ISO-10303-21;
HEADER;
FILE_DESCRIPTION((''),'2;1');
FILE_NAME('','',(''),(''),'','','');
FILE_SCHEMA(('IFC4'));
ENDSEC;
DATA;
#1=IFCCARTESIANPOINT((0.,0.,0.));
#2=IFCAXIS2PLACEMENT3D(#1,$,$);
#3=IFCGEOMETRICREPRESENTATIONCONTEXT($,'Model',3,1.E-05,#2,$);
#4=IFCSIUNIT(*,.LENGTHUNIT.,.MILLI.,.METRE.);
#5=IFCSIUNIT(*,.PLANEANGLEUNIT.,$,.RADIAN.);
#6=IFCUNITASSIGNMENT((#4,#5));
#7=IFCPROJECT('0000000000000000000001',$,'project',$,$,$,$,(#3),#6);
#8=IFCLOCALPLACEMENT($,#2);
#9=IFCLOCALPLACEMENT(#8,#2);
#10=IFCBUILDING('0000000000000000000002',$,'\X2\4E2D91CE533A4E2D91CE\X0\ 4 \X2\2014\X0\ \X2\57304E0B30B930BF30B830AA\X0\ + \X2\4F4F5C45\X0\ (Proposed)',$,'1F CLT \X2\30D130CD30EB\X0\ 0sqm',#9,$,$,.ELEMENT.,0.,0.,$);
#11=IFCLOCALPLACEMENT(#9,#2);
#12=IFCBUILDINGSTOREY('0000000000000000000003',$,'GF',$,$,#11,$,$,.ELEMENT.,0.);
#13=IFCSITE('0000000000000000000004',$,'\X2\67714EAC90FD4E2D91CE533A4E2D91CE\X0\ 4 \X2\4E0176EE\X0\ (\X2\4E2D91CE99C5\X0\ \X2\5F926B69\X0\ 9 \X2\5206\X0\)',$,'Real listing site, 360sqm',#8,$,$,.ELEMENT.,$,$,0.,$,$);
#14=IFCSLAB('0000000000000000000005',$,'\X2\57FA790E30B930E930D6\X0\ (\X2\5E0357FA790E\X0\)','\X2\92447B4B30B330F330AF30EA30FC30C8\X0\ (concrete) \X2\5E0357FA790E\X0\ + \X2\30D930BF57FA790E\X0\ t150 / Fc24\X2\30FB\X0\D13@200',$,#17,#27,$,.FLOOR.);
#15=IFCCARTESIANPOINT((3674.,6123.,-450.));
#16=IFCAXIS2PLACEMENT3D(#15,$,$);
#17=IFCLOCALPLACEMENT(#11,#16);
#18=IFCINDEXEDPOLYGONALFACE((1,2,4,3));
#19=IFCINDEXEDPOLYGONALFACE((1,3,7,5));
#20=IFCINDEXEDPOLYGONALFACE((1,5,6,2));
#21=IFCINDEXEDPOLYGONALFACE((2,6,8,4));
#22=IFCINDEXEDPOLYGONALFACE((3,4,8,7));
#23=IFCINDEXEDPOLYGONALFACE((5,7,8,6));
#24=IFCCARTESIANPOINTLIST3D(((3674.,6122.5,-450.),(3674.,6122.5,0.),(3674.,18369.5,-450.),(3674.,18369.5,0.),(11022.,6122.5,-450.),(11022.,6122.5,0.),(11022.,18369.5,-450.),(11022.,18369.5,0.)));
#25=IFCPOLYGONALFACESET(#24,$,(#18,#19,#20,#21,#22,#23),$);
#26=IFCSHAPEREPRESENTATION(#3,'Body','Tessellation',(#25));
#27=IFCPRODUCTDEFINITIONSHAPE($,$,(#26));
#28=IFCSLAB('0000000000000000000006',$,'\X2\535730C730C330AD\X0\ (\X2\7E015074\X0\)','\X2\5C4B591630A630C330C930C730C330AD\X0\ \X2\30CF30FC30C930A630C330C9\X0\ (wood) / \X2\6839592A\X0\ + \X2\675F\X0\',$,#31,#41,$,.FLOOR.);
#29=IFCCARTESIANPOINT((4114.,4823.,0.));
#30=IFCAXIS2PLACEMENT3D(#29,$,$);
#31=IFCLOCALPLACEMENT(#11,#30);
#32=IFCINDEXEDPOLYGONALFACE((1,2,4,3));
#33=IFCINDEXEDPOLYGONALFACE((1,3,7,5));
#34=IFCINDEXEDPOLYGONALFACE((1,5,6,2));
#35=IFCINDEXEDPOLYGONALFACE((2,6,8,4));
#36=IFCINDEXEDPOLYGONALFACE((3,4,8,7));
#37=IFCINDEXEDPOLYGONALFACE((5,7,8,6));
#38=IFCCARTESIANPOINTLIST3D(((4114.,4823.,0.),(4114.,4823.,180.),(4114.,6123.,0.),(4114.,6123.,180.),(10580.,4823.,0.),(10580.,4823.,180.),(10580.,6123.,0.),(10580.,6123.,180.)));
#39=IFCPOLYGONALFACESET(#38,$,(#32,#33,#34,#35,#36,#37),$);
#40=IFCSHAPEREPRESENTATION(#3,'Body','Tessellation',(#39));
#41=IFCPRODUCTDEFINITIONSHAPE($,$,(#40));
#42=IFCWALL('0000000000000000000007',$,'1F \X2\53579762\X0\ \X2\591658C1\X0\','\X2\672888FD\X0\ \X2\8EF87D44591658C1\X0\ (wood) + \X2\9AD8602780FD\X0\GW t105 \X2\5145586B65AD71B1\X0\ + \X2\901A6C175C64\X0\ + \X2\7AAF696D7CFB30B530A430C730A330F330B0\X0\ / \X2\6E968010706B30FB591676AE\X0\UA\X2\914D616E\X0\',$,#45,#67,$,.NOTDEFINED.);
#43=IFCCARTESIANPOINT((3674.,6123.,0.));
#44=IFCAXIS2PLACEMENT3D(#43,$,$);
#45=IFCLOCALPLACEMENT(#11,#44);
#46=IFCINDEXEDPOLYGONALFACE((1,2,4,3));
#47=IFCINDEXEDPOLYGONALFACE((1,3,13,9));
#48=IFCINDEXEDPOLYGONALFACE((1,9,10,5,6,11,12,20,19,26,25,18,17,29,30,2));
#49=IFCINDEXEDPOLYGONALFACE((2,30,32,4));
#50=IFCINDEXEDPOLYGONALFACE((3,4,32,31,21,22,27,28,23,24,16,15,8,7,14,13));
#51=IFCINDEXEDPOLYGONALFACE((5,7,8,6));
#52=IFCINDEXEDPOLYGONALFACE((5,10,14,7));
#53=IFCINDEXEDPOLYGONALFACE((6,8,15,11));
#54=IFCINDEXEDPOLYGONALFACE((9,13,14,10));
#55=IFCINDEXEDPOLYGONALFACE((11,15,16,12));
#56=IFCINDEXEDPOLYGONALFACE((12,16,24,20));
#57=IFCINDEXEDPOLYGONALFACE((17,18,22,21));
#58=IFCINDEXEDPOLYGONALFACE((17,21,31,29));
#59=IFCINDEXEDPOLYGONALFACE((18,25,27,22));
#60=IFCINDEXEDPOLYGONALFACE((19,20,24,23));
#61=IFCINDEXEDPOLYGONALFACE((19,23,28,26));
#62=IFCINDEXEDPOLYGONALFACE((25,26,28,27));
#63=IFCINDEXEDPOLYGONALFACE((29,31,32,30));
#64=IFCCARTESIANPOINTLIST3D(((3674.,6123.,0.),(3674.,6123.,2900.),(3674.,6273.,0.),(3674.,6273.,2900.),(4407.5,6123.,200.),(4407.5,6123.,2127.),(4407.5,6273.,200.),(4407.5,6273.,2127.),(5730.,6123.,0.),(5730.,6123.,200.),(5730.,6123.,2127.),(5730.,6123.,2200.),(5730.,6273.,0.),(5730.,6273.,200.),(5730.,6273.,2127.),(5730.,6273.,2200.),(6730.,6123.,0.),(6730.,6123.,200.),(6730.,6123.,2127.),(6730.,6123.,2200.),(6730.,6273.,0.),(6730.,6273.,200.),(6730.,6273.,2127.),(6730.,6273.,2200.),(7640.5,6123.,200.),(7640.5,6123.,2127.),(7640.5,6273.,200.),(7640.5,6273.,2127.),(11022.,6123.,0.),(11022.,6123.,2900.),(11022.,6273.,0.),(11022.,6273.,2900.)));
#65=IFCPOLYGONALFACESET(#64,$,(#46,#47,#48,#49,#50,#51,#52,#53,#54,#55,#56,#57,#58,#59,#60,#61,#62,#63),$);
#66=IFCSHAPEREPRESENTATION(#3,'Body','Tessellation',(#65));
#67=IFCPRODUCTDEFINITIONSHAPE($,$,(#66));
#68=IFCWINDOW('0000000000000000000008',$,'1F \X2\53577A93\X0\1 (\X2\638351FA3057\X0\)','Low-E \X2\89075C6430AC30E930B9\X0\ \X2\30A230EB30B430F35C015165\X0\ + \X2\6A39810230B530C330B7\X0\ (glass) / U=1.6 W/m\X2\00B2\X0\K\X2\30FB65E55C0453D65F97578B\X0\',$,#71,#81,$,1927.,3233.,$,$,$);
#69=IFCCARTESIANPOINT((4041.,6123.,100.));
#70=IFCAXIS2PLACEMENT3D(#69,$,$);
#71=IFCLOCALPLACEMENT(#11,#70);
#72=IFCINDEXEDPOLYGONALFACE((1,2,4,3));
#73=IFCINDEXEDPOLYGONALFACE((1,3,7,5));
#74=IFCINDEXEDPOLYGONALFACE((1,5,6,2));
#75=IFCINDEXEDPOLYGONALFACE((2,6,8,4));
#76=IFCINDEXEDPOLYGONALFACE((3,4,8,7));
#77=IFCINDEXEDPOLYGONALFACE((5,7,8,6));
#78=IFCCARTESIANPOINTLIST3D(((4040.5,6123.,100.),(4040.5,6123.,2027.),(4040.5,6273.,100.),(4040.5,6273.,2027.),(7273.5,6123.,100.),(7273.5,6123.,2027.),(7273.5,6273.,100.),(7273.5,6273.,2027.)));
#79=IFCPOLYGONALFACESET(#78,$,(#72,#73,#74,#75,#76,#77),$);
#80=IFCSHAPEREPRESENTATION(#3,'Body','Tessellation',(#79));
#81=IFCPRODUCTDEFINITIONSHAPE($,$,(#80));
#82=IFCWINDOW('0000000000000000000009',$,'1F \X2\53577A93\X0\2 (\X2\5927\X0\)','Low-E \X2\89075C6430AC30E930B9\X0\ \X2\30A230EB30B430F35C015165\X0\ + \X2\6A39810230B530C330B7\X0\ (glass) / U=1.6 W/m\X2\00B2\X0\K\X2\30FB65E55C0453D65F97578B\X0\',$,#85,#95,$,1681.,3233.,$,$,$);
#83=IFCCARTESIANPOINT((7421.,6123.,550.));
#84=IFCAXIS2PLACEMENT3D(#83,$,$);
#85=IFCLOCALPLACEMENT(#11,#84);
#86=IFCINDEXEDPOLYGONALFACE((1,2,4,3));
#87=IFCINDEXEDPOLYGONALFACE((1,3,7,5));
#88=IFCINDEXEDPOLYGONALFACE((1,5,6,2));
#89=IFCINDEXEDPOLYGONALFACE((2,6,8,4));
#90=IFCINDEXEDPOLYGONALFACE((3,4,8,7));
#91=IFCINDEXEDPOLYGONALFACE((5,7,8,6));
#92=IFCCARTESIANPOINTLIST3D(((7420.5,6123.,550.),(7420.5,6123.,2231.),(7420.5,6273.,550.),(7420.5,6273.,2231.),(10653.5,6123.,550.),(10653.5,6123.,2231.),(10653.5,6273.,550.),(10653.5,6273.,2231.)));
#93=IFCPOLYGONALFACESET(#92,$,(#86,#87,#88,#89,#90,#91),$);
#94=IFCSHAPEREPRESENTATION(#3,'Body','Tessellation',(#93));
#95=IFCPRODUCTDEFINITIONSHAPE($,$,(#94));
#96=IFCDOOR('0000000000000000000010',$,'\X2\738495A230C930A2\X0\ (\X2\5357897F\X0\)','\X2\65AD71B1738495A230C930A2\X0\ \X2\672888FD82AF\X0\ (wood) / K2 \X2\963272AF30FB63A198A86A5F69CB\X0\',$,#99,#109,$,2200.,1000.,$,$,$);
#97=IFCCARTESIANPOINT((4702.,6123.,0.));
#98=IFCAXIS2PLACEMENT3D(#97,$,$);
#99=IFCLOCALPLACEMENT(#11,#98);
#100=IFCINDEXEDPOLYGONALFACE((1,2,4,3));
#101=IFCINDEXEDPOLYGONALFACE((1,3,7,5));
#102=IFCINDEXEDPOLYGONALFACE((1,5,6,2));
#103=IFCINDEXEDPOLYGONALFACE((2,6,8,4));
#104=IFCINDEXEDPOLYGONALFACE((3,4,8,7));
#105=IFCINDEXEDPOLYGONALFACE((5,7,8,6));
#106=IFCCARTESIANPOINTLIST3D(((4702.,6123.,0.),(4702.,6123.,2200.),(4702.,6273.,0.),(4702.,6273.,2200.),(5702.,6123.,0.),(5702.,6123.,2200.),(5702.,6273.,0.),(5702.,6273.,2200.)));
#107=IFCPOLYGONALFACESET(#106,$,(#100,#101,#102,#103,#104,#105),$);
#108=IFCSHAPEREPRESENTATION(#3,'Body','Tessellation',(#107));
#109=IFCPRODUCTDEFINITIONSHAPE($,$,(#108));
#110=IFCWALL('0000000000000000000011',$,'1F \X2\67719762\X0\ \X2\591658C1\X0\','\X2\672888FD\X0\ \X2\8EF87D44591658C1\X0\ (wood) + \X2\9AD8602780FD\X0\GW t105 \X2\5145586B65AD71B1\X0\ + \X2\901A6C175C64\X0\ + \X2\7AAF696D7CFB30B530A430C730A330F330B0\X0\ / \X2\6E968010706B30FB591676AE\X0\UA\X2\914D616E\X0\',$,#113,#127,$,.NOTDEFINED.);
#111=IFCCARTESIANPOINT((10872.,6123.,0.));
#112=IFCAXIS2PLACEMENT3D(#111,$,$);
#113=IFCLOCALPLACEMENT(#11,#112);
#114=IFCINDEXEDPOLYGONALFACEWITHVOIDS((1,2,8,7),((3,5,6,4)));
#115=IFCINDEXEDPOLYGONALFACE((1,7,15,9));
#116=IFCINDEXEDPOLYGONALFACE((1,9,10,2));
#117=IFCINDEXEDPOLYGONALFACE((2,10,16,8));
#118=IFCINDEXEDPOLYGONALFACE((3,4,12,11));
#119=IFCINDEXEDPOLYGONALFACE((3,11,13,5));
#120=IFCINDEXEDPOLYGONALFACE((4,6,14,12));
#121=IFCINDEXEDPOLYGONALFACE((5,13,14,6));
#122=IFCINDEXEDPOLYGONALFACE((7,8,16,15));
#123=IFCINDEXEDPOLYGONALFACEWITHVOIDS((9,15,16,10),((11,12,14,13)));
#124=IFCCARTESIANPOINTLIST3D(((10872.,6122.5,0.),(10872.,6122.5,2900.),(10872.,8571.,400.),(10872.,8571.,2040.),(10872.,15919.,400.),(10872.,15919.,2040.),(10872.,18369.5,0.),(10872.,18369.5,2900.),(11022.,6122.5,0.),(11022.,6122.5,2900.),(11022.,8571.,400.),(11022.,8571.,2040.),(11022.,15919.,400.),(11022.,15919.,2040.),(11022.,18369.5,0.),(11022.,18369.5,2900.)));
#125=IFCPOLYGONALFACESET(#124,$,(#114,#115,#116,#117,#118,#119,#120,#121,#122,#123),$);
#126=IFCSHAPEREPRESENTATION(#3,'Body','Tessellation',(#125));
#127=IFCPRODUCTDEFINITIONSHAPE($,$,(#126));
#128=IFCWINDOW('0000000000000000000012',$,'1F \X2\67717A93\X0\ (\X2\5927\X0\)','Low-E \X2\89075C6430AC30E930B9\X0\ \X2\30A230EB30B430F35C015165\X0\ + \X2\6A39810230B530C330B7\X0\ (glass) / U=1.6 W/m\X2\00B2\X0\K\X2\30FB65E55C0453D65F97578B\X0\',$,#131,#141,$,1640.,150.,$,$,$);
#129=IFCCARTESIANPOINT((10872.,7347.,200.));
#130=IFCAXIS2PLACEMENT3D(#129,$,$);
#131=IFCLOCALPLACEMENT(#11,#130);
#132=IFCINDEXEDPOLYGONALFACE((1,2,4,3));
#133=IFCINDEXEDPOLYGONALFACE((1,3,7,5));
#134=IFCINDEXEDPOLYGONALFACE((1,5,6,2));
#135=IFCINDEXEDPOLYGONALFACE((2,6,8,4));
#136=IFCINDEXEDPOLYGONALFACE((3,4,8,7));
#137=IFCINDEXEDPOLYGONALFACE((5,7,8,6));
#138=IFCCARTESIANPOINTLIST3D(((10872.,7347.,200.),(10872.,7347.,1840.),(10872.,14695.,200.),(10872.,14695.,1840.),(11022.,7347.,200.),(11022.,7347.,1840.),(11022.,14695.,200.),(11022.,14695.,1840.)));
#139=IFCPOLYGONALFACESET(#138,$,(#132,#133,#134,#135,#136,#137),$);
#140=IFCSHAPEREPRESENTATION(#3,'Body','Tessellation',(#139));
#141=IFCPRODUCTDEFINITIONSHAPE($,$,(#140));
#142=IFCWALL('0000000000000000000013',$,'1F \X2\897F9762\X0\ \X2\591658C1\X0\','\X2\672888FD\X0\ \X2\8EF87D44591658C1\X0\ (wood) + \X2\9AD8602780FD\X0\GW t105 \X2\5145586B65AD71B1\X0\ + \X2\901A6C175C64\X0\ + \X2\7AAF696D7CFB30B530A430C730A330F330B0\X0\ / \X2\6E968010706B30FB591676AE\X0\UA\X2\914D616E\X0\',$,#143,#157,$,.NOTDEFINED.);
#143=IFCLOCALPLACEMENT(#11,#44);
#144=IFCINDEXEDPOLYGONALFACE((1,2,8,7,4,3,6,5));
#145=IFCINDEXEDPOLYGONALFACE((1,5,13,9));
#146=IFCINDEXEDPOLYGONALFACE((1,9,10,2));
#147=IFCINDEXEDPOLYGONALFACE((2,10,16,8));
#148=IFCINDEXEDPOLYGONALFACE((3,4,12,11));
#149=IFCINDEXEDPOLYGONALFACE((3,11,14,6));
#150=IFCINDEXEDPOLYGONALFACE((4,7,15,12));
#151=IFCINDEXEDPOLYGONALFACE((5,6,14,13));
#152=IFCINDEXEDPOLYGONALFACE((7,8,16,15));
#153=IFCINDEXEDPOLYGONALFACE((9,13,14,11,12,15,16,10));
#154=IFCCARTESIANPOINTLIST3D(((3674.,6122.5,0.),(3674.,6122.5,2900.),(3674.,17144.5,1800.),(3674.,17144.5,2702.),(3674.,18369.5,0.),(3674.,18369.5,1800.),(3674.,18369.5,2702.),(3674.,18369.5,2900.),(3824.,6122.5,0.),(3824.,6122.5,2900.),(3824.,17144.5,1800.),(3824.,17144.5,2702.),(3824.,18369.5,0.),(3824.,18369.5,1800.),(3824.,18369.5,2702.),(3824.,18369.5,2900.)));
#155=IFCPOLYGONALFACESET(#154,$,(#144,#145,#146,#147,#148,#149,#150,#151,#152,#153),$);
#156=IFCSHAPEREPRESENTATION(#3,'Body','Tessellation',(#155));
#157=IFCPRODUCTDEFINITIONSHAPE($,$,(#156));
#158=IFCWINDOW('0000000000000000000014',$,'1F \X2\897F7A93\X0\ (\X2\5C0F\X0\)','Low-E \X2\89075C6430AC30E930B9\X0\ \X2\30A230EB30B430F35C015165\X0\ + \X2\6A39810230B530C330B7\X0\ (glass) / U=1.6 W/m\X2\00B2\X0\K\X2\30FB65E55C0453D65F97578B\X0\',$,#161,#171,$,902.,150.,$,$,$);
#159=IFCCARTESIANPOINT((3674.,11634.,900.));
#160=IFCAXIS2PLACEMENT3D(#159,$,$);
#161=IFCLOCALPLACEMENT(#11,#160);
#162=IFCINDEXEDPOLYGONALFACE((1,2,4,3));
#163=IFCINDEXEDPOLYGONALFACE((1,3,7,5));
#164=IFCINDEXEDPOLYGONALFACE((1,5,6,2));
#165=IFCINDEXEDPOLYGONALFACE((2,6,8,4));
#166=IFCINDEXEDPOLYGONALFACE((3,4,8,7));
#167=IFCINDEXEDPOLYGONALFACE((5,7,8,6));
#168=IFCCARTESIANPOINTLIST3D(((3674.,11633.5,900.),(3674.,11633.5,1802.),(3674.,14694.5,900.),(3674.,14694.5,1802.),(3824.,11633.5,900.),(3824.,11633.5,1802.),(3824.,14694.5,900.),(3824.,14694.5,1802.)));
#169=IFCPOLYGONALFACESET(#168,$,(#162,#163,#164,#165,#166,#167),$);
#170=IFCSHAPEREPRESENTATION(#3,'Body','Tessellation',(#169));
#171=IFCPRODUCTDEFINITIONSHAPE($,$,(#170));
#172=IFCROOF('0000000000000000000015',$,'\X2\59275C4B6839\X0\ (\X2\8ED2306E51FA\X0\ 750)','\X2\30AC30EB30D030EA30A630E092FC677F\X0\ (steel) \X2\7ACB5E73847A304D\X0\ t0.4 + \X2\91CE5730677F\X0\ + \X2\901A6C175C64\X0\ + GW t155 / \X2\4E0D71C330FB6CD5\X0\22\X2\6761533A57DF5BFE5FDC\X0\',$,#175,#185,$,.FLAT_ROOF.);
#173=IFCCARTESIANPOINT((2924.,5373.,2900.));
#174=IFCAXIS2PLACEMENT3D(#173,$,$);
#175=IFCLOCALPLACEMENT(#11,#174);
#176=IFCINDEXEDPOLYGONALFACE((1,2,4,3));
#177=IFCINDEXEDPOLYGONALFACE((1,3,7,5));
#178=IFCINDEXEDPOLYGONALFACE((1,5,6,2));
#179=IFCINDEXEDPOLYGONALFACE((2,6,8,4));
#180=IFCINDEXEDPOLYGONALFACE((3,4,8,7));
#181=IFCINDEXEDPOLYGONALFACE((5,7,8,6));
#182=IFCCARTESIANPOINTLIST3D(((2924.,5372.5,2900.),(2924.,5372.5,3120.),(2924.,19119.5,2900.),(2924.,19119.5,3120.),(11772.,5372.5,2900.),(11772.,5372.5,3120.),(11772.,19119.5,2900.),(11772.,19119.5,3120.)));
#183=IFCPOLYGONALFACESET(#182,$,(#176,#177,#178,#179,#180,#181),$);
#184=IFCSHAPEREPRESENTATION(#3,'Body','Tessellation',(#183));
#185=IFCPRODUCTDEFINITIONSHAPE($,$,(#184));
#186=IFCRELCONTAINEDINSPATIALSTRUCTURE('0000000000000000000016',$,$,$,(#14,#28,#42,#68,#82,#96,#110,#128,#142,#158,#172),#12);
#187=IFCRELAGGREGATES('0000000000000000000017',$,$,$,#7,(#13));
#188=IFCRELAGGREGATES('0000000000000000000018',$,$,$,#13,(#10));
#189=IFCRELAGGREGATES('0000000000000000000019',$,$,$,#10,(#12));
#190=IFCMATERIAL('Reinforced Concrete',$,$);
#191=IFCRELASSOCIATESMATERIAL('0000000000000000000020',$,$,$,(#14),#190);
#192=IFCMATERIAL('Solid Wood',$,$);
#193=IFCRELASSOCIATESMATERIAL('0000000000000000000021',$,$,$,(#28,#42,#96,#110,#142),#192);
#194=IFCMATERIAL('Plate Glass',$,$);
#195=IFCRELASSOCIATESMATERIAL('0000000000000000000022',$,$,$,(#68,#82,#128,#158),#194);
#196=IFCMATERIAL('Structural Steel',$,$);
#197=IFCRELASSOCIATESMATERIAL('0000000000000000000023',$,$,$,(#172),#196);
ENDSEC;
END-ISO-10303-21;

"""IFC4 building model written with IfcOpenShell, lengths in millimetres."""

from ifc_helpers import new_model, si_unit, frame, frame_2d, origin, place, context, project, spatial, rectangle, extrude, material, element, fill, save


model = new_model("IFC4")

# Units and contexts
model_context = context("Model", 3, precision=1e-05, world=origin())
ifc_project = project(units=[si_unit("LENGTHUNIT", "METRE", prefix="MILLI"), si_unit("PLANEANGLEUNIT", "RADIAN")], contexts=[model_context])

# Site, building, storey
site_placement = place(None, origin())
site = spatial("IfcSite", under=ifc_project, at=site_placement, Name="東京都中野区中野 4 丁目 (中野駅 徒歩 9 分)", ObjectType="Real listing site, 360sqm", CompositionType="ELEMENT", RefElevation=0.0)
building_placement = place(site_placement, origin())
building = spatial("IfcBuilding", under=site, at=building_placement, Name="中野区中野 4 — 地下スタジオ + 住居 (Proposed)", ObjectType="1F CLT パネル 0sqm", CompositionType="ELEMENT", ElevationOfRefHeight=0.0, ElevationOfTerrain=0.0)
storey_placement = place(building_placement, origin())
storey = spatial("IfcBuildingStorey", under=building, at=storey_placement, Name="GF", CompositionType="ELEMENT", Elevation=0.0)

# Slabs
ifc_material_1 = material(Name="Reinforced Concrete")
slab_1_placement = place(storey_placement, frame((3674.0, 6123.0, -450.0)))
element("IfcSlab", 1, at=slab_1_placement, inside=storey, material=ifc_material_1, Name="基礎スラブ (布基礎)", Description="鉄筋コンクリート (concrete) 布基礎 + ベタ基礎 t150 / Fc24・D13@200", PredefinedType="FLOOR", context=model_context, shape_type="SweptSolid", body=[
    extrude(rectangle(XDim=7348.0, YDim=12247.0, at=frame_2d((3674.0, 6123.0))), frame((3674.0, 6123.0, -450.0)), (0.0, 0.0, 1.0), 450.0),
])
ifc_material_2 = material(Name="Solid Wood")
slab_2_placement = place(storey_placement, frame((4114.0, 4823.0, 0.0)))
element("IfcSlab", 2, at=slab_2_placement, inside=storey, material=ifc_material_2, Name="南デッキ (縁側)", Description="屋外ウッドデッキ ハードウッド (wood) / 根太 + 束", PredefinedType="FLOOR", context=model_context, shape_type="SweptSolid", body=[
    extrude(rectangle(XDim=6466.0, YDim=1300.0, at=frame_2d((3233.0, 650.0))), frame((4114.0, 4823.0, 0.0)), (0.0, 0.0, 1.0), 180.0),
])

# Wall, openings, windows, door
wall_1_placement = place(storey_placement, frame((3674.0, 6123.0, 0.0)))
wall_1 = element("IfcWall", 3, at=wall_1_placement, inside=storey, material=ifc_material_2, Name="1F 南面 外壁", Description="木製 軸組外壁 (wood) + 高性能GW t105 充填断熱 + 通気層 + 窯業系サイディング / 準耐火・外皮UA配慮", PredefinedType="NOTDEFINED", context=model_context, shape_type="SweptSolid", body=[
    extrude(rectangle(XDim=7348.0, YDim=150.0, at=frame_2d((3674.0, 75.0))), frame((3674.0, 6123.0, 0.0)), (0.0, 0.0, 1.0), 2900.0),
])
opening_1_placement = place(storey_placement, frame((4041.0, 6123.0, 100.0)))
opening_1 = element("IfcOpeningElement", 4, at=opening_1_placement, cuts=wall_1, PredefinedType="NOTDEFINED", context=model_context, shape_type="SweptSolid", body=[
    extrude(rectangle(XDim=3233.0, YDim=150.0, at=frame_2d((1616.0, 75.0))), frame((4041.0, 6123.0, 100.0)), (0.0, 0.0, 1.0), 1927.0),
])
opening_2_placement = place(storey_placement, frame((7421.0, 6123.0, 550.0)))
opening_2 = element("IfcOpeningElement", 5, at=opening_2_placement, cuts=wall_1, PredefinedType="NOTDEFINED", context=model_context, shape_type="SweptSolid", body=[
    extrude(rectangle(XDim=3233.0, YDim=150.0, at=frame_2d((1616.0, 75.0))), frame((7421.0, 6123.0, 550.0)), (0.0, 0.0, 1.0), 1681.0),
])
opening_3_placement = place(storey_placement, frame((4702.0, 6123.0, 0.0)))
opening_3 = element("IfcOpeningElement", 6, at=opening_3_placement, cuts=wall_1, PredefinedType="NOTDEFINED", context=model_context, shape_type="SweptSolid", body=[
    extrude(rectangle(XDim=1000.0, YDim=150.0, at=frame_2d((500.0, 75.0))), frame((4702.0, 6123.0, 0.0)), (0.0, 0.0, 1.0), 2200.0),
])
ifc_material_3 = material(Name="Plate Glass")
window_1_placement = place(storey_placement, frame((4041.0, 6123.0, 100.0)))
window_1 = element("IfcWindow", 7, at=window_1_placement, inside=storey, material=ifc_material_3, Name="1F 南窓1 (掃出し)", Description="Low-E 複層ガラス アルゴン封入 + 樹脂サッシ (glass) / U=1.6 W/m²K・日射取得型", OverallHeight=1927.0, OverallWidth=3233.0, context=model_context, shape_type="SweptSolid", body=[
    extrude(rectangle(XDim=3233.0, YDim=150.0, at=frame_2d((1616.0, 75.0))), frame((4041.0, 6123.0, 100.0)), (0.0, 0.0, 1.0), 1927.0),
])
fill(opening_1, window_1)
window_2_placement = place(storey_placement, frame((7421.0, 6123.0, 550.0)))
window_2 = element("IfcWindow", 8, at=window_2_placement, inside=storey, material=ifc_material_3, Name="1F 南窓2 (大)", Description="Low-E 複層ガラス アルゴン封入 + 樹脂サッシ (glass) / U=1.6 W/m²K・日射取得型", OverallHeight=1681.0, OverallWidth=3233.0, context=model_context, shape_type="SweptSolid", body=[
    extrude(rectangle(XDim=3233.0, YDim=150.0, at=frame_2d((1616.0, 75.0))), frame((7421.0, 6123.0, 550.0)), (0.0, 0.0, 1.0), 1681.0),
])
fill(opening_2, window_2)
door_placement = place(storey_placement, frame((4702.0, 6123.0, 0.0)))
door = element("IfcDoor", 9, at=door_placement, inside=storey, material=ifc_material_2, Name="玄関ドア (南西)", Description="断熱玄関ドア 木製芯 (wood) / K2 防犯・採風機構", OverallHeight=2200.0, OverallWidth=1000.0, context=model_context, shape_type="SweptSolid", body=[
    extrude(rectangle(XDim=1000.0, YDim=150.0, at=frame_2d((500.0, 75.0))), frame((4702.0, 6123.0, 0.0)), (0.0, 0.0, 1.0), 2200.0),
])
fill(opening_3, door)

# Walls, openings, windows
wall_2_placement = place(storey_placement, frame((10872.0, 6123.0, 0.0)))
wall_2 = element("IfcWall", 10, at=wall_2_placement, inside=storey, material=ifc_material_2, Name="1F 東面 外壁", Description="木製 軸組外壁 (wood) + 高性能GW t105 充填断熱 + 通気層 + 窯業系サイディング / 準耐火・外皮UA配慮", PredefinedType="NOTDEFINED", context=model_context, shape_type="SweptSolid", body=[
    extrude(rectangle(XDim=150.0, YDim=12247.0, at=frame_2d((75.0, 6123.0))), frame((10872.0, 6123.0, 0.0)), (0.0, 0.0, 1.0), 2900.0),
])
opening_4_placement = place(storey_placement, frame((10872.0, 7347.0, 200.0)))
opening_4 = element("IfcOpeningElement", 11, at=opening_4_placement, cuts=wall_2, PredefinedType="NOTDEFINED", context=model_context, shape_type="SweptSolid", body=[
    extrude(rectangle(XDim=150.0, YDim=7348.0, at=frame_2d((75.0, 3674.0))), frame((10872.0, 7347.0, 200.0)), (0.0, 0.0, 1.0), 1640.0),
])
window_3_placement = place(storey_placement, frame((10872.0, 7347.0, 200.0)))
window_3 = element("IfcWindow", 12, at=window_3_placement, inside=storey, material=ifc_material_3, Name="1F 東窓 (大)", Description="Low-E 複層ガラス アルゴン封入 + 樹脂サッシ (glass) / U=1.6 W/m²K・日射取得型", OverallHeight=1640.0, OverallWidth=150.0, context=model_context, shape_type="SweptSolid", body=[
    extrude(rectangle(XDim=150.0, YDim=7348.0, at=frame_2d((75.0, 3674.0))), frame((10872.0, 7347.0, 200.0)), (0.0, 0.0, 1.0), 1640.0),
])
fill(opening_4, window_3)
wall_3_placement = place(storey_placement, frame((3674.0, 6123.0, 0.0)))
wall_3 = element("IfcWall", 13, at=wall_3_placement, inside=storey, material=ifc_material_2, Name="1F 西面 外壁", Description="木製 軸組外壁 (wood) + 高性能GW t105 充填断熱 + 通気層 + 窯業系サイディング / 準耐火・外皮UA配慮", PredefinedType="NOTDEFINED", context=model_context, shape_type="SweptSolid", body=[
    extrude(rectangle(XDim=150.0, YDim=12247.0, at=frame_2d((75.0, 6123.0))), frame((3674.0, 6123.0, 0.0)), (0.0, 0.0, 1.0), 2900.0),
])
opening_5_placement = place(storey_placement, frame((3674.0, 11634.0, 900.0)))
opening_5 = element("IfcOpeningElement", 14, at=opening_5_placement, cuts=wall_3, PredefinedType="NOTDEFINED", context=model_context, shape_type="SweptSolid", body=[
    extrude(rectangle(XDim=150.0, YDim=3061.0, at=frame_2d((75.0, 1530.0))), frame((3674.0, 11634.0, 900.0)), (0.0, 0.0, 1.0), 902.0),
])
window_4_placement = place(storey_placement, frame((3674.0, 11634.0, 900.0)))
window_4 = element("IfcWindow", 15, at=window_4_placement, inside=storey, material=ifc_material_3, Name="1F 西窓 (小)", Description="Low-E 複層ガラス アルゴン封入 + 樹脂サッシ (glass) / U=1.6 W/m²K・日射取得型", OverallHeight=902.0, OverallWidth=150.0, context=model_context, shape_type="SweptSolid", body=[
    extrude(rectangle(XDim=150.0, YDim=3061.0, at=frame_2d((75.0, 1530.0))), frame((3674.0, 11634.0, 900.0)), (0.0, 0.0, 1.0), 902.0),
])
fill(opening_5, window_4)

# Roof
ifc_material_4 = material(Name="Structural Steel")
roof_placement = place(storey_placement, frame((2924.0, 5373.0, 2900.0)))
element("IfcRoof", 16, at=roof_placement, inside=storey, material=ifc_material_4, Name="大屋根 (軒の出 750)", Description="ガルバリウム鋼板 (steel) 立平葺き t0.4 + 野地板 + 通気層 + GW t155 / 不燃・法22条区域対応", PredefinedType="FLAT_ROOF", context=model_context, shape_type="SweptSolid", body=[
    extrude(rectangle(XDim=8848.0, YDim=13747.0, at=frame_2d((4424.0, 6873.0))), frame((2924.0, 5373.0, 2900.0)), (0.0, 0.0, 1.0), 220.0),
])

save(model, "model.ifc")
